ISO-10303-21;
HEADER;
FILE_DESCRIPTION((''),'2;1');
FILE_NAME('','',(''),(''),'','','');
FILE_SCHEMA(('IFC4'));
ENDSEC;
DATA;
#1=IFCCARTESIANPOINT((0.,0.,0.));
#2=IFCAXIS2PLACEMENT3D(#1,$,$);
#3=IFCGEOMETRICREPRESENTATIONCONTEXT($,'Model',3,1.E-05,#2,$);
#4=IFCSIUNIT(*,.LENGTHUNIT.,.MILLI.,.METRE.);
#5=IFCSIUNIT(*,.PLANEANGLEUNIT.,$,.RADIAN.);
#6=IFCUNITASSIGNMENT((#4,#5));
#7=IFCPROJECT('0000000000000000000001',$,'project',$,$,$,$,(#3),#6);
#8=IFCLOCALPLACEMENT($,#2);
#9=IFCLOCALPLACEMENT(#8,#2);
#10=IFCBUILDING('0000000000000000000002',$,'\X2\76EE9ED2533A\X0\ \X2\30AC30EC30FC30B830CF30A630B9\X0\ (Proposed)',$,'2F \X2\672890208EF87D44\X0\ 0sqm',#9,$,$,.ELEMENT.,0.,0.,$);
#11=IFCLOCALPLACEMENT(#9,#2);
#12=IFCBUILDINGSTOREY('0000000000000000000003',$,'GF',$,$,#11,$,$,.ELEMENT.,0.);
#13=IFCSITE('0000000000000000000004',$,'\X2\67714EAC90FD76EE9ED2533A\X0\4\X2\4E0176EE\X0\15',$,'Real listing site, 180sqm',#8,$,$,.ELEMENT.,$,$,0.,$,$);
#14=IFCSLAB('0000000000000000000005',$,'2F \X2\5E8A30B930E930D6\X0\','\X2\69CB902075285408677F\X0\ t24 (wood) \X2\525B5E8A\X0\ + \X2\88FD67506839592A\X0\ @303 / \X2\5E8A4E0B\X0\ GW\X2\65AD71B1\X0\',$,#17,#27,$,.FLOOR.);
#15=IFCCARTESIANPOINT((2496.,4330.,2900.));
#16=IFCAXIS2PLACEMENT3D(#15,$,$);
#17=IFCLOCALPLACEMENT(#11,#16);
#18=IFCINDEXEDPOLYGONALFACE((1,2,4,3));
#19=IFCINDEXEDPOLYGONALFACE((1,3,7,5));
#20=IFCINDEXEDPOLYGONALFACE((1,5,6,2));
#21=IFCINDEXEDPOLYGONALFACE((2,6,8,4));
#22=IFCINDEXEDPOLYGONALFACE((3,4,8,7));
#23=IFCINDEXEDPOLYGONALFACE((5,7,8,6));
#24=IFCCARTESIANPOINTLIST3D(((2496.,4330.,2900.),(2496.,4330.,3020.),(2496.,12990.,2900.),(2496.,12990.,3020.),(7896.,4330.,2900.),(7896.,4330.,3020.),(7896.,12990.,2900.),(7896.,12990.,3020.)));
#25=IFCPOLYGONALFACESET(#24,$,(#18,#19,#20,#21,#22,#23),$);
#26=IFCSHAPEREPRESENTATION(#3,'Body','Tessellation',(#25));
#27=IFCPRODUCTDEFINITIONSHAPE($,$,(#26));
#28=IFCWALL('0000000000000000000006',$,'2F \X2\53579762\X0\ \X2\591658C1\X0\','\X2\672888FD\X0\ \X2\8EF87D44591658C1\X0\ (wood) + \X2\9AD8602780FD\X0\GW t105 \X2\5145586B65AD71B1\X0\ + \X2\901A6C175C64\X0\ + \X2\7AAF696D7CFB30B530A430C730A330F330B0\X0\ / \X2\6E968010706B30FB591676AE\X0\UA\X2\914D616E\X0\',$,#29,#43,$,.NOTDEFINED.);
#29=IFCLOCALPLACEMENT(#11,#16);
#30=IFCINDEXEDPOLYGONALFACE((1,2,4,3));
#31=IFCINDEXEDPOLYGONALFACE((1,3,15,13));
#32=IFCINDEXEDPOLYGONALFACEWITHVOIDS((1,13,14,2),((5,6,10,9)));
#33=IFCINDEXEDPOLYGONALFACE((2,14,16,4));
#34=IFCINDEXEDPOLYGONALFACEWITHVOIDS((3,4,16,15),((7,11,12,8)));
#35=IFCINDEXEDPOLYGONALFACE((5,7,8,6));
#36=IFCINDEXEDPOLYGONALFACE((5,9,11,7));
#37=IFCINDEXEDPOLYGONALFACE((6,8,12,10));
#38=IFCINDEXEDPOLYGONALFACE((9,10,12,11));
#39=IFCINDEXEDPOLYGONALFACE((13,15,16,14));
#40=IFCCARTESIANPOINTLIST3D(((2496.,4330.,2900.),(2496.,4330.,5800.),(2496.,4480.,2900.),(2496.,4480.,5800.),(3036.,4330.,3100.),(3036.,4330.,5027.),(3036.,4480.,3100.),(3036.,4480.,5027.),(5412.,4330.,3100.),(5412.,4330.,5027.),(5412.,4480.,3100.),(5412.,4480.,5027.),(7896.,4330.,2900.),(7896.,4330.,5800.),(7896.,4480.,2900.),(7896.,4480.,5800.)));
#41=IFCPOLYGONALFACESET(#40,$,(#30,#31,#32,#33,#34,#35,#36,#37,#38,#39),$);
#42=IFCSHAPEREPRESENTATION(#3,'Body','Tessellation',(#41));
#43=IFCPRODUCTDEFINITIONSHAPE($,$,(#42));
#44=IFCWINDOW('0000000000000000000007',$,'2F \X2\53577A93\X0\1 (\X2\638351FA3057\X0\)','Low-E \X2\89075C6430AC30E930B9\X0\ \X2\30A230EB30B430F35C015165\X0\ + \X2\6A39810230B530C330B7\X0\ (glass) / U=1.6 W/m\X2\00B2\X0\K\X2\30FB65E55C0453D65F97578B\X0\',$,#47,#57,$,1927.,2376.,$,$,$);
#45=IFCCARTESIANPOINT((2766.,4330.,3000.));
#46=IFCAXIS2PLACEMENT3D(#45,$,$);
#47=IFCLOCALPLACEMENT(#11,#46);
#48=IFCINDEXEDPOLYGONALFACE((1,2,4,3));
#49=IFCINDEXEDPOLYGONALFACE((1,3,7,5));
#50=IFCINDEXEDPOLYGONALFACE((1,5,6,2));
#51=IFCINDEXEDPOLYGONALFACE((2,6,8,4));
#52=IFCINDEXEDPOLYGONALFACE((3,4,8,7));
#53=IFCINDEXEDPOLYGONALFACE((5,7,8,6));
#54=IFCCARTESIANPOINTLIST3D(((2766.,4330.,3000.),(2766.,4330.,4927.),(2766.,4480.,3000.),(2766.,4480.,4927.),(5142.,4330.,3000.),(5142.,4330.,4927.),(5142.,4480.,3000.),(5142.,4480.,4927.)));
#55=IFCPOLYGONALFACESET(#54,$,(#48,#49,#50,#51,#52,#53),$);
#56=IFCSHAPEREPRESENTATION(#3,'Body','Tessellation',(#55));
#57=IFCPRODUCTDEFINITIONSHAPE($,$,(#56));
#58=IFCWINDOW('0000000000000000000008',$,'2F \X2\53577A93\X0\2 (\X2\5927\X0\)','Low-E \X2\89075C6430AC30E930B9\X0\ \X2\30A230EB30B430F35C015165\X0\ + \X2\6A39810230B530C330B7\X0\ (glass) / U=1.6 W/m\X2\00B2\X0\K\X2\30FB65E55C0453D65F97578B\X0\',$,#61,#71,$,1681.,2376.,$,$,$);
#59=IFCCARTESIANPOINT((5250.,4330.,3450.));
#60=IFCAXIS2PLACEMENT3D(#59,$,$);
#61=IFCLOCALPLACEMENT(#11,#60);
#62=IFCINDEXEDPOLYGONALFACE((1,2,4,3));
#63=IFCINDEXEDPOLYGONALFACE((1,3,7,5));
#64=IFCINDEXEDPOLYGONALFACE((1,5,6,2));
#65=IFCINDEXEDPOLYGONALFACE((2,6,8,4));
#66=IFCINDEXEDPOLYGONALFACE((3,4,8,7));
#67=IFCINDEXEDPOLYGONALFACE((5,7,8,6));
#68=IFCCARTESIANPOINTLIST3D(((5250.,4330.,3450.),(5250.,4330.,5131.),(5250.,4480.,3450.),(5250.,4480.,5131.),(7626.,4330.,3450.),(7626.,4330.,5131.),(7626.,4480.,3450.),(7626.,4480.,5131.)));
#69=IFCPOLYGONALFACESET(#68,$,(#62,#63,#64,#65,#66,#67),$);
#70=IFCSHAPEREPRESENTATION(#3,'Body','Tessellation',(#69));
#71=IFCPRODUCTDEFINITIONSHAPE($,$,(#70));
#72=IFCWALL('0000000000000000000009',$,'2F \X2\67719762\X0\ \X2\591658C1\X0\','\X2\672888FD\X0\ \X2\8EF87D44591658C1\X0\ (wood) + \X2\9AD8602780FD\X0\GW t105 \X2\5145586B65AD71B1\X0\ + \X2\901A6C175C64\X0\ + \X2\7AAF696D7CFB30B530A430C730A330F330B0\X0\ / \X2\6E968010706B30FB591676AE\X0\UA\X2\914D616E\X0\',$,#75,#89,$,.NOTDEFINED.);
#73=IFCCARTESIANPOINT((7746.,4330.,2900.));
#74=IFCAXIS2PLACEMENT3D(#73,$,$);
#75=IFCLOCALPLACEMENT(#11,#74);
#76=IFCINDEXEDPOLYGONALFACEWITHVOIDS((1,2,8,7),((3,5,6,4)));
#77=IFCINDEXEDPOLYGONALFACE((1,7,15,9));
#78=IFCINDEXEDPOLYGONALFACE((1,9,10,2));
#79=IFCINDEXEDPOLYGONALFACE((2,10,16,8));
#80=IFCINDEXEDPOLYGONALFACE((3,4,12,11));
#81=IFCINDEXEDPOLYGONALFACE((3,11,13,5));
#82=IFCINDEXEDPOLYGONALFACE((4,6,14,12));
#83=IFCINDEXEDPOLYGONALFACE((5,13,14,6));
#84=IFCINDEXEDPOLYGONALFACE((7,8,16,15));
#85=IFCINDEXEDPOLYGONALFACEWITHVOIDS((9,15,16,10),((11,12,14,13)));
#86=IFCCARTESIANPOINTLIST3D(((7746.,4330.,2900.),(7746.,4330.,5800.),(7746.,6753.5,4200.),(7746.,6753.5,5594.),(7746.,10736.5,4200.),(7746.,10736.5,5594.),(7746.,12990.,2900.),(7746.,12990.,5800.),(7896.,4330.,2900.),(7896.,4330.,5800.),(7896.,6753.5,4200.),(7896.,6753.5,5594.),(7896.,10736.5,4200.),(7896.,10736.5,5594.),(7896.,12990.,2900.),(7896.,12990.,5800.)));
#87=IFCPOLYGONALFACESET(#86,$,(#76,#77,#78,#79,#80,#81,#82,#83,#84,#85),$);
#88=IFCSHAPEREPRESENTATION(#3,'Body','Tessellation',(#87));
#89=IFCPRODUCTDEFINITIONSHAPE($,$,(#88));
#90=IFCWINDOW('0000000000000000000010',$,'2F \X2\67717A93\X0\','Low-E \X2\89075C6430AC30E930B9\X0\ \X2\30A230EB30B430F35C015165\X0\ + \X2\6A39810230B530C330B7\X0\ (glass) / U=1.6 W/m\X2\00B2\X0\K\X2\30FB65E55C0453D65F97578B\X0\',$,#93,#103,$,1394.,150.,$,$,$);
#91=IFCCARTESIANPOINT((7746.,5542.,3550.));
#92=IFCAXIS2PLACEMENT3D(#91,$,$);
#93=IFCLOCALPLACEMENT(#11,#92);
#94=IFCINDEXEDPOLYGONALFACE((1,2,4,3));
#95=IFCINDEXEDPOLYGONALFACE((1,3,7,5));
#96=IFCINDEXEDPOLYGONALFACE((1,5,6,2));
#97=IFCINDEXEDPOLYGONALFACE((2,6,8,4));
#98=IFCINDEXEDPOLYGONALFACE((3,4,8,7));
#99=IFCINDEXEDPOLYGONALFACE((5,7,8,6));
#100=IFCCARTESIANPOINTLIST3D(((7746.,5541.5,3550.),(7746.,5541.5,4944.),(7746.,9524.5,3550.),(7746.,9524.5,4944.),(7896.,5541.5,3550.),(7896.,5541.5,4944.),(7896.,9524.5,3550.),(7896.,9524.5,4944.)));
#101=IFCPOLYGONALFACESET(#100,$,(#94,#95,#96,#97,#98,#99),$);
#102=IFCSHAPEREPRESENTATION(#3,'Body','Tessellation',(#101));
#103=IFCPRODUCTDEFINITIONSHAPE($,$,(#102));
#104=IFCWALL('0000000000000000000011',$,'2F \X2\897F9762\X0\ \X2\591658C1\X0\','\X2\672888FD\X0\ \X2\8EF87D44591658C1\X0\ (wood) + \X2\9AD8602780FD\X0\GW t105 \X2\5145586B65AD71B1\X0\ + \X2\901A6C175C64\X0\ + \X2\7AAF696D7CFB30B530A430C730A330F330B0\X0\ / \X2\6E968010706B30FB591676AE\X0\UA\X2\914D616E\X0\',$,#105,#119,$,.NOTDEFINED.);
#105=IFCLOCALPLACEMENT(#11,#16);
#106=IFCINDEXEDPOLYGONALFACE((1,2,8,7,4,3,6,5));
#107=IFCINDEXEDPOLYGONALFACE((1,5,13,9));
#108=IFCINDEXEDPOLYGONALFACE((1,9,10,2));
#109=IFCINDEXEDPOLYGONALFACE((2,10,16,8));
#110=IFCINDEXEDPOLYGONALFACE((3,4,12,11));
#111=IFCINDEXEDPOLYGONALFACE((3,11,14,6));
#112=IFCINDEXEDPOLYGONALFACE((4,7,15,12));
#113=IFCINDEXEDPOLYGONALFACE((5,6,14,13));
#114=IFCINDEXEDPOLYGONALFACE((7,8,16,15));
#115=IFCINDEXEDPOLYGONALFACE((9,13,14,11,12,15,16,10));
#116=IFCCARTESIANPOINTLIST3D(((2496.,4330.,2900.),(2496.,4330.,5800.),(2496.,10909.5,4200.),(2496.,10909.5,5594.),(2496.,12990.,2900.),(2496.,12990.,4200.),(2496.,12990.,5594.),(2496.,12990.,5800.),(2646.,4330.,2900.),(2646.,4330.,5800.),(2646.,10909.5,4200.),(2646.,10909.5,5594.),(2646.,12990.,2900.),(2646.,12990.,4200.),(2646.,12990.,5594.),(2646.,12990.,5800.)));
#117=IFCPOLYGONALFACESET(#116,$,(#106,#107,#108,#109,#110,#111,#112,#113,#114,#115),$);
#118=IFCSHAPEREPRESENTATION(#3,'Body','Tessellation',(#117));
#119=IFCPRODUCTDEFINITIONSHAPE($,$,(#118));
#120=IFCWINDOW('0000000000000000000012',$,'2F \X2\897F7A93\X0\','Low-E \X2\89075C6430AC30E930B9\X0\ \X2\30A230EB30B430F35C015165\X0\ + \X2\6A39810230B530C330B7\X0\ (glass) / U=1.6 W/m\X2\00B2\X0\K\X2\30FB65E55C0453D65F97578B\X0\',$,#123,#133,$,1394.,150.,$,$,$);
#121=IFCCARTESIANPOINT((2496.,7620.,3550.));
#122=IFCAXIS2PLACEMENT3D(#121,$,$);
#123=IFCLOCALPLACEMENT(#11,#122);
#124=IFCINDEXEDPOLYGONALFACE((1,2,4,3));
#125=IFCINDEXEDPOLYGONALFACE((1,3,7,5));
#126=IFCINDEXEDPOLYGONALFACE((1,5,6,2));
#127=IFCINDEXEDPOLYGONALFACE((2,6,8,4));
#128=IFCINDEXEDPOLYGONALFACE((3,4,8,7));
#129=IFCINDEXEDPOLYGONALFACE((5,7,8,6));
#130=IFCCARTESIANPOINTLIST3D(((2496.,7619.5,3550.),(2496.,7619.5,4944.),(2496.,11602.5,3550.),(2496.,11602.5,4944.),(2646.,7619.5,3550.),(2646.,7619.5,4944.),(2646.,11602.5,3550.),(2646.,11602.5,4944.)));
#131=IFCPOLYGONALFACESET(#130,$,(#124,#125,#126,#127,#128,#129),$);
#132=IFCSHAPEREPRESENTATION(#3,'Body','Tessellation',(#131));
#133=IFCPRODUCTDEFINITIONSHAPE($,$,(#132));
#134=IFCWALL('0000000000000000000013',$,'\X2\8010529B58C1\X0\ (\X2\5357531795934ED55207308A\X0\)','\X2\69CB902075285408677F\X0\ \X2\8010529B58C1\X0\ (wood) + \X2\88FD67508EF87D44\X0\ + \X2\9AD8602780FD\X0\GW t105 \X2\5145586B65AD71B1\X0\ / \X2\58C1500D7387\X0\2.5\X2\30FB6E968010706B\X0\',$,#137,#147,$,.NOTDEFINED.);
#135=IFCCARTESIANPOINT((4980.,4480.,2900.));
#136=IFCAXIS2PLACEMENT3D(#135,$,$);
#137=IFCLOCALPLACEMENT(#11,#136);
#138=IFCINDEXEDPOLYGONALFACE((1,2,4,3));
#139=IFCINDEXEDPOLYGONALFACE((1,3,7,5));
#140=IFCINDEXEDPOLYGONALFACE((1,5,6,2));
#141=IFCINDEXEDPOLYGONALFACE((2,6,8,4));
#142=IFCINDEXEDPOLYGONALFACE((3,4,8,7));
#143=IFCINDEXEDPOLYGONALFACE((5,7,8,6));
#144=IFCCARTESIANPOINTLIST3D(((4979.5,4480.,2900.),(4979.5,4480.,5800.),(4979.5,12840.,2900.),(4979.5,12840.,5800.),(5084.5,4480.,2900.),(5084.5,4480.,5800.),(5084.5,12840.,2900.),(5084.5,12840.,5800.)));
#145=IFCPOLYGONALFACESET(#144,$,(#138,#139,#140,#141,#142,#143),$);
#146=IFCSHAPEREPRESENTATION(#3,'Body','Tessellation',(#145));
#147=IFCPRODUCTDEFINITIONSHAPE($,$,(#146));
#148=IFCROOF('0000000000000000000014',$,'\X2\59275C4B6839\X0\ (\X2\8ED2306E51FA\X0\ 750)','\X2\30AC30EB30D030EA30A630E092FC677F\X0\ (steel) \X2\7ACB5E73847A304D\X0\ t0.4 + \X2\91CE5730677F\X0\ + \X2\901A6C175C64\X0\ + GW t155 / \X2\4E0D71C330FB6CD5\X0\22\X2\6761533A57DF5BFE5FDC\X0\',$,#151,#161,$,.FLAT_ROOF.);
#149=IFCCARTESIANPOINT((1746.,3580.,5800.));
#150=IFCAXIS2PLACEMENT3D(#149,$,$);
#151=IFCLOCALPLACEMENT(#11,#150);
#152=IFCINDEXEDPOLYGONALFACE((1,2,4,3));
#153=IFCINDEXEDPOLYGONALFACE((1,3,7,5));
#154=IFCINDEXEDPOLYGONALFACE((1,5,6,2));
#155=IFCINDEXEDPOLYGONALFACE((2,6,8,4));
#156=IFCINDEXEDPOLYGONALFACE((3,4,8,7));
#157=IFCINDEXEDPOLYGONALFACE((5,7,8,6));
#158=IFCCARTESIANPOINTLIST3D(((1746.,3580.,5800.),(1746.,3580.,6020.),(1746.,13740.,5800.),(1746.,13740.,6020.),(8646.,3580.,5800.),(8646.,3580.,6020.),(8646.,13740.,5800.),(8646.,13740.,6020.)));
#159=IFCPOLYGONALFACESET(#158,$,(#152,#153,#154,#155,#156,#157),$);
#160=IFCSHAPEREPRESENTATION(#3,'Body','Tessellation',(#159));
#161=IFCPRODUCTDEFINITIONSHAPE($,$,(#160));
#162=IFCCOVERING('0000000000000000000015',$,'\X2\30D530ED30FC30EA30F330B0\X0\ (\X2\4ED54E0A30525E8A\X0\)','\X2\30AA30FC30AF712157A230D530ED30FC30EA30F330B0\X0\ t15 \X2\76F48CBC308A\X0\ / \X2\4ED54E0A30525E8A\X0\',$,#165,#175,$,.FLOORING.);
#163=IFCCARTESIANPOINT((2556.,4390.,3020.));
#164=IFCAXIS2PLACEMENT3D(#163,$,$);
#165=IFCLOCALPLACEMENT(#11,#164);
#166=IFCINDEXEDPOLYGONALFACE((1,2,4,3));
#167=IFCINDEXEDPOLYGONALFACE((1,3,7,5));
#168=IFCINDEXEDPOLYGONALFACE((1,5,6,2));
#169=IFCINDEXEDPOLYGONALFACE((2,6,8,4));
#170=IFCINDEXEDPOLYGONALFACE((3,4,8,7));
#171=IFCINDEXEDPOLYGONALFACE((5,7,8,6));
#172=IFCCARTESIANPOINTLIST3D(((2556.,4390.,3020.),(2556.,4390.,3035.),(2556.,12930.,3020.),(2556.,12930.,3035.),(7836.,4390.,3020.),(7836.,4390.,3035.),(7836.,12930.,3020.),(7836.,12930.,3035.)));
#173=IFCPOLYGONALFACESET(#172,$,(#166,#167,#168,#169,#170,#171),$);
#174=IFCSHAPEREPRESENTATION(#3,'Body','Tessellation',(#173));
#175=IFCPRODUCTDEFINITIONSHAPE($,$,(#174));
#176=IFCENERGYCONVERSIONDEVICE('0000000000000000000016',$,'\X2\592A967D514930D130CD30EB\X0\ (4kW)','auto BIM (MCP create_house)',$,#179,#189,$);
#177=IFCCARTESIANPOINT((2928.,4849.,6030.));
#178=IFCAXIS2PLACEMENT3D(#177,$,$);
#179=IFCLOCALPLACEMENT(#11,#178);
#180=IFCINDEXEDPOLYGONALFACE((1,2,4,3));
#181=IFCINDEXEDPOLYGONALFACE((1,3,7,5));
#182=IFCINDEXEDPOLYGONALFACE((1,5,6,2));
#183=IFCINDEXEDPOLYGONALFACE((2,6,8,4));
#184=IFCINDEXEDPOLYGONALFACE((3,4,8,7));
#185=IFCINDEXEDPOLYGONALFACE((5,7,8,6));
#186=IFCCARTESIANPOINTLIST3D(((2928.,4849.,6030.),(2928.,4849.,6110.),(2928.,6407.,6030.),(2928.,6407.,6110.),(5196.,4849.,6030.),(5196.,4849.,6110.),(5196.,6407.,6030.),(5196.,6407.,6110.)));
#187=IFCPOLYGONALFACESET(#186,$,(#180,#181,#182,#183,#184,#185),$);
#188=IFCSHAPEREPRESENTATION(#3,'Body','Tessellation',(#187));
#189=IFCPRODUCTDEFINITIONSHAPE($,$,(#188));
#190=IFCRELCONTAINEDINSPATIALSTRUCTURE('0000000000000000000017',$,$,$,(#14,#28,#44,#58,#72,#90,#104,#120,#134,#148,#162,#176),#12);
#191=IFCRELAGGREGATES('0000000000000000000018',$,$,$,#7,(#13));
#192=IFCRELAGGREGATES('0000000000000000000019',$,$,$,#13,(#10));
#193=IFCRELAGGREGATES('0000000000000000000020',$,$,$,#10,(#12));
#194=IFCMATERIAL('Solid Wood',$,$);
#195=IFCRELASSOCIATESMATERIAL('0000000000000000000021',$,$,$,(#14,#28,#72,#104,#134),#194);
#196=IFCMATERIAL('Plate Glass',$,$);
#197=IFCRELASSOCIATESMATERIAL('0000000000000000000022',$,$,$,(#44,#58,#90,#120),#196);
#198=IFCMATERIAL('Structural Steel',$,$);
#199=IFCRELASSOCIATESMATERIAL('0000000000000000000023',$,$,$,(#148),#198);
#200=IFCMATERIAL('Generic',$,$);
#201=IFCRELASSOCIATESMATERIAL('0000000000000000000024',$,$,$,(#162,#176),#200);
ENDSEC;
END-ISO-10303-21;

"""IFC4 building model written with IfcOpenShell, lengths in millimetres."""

from ifc_helpers import new_model, si_unit, frame, frame_2d, origin, place, context, project, spatial, rectangle, extrude, material, element, fill, save


model = new_model("IFC4")

# Units and contexts
model_context = context("Model", 3, precision=1e-05, world=origin())
ifc_project = project(units=[si_unit("LENGTHUNIT", "METRE", prefix="MILLI"), si_unit("PLANEANGLEUNIT", "RADIAN")], contexts=[model_context])

# Site, building, storey
site_placement = place(None, origin())
site = spatial("IfcSite", under=ifc_project, at=site_placement, Name="東京都目黒区4丁目15", ObjectType="Real listing site, 180sqm", CompositionType="ELEMENT", RefElevation=0.0)
building_placement = place(site_placement, origin())
building = spatial("IfcBuilding", under=site, at=building_placement, Name="目黒区 ガレージハウス (Proposed)", ObjectType="2F 木造軸組 0sqm", CompositionType="ELEMENT", ElevationOfRefHeight=0.0, ElevationOfTerrain=0.0)
storey_placement = place(building_placement, origin())
storey = spatial("IfcBuildingStorey", under=building, at=storey_placement, Name="GF", CompositionType="ELEMENT", Elevation=0.0)

# Slab
ifc_material_1 = material(Name="Solid Wood")
slab_placement = place(storey_placement, frame((2496.0, 4330.0, 2900.0)))
element("IfcSlab", 1, at=slab_placement, inside=storey, material=ifc_material_1, Name="2F 床スラブ", Description="構造用合板 t24 (wood) 剛床 + 製材根太 @303 / 床下 GW断熱", PredefinedType="FLOOR", context=model_context, shape_type="SweptSolid", body=[
    extrude(rectangle(XDim=5400.0, YDim=8660.0, at=frame_2d((2700.0, 4330.0))), frame((2496.0, 4330.0, 2900.0)), (0.0, 0.0, 1.0), 120.0),
])

# Wall, openings, windows
wall_1_placement = place(storey_placement, frame((2496.0, 4330.0, 2900.0)))
wall_1 = element("IfcWall", 2, at=wall_1_placement, inside=storey, material=ifc_material_1, Name="2F 南面 外壁", Description="木製 軸組外壁 (wood) + 高性能GW t105 充填断熱 + 通気層 + 窯業系サイディング / 準耐火・外皮UA配慮", PredefinedType="NOTDEFINED", context=model_context, shape_type="SweptSolid", body=[
    extrude(rectangle(XDim=5400.0, YDim=150.0, at=frame_2d((2700.0, 75.0))), frame((2496.0, 4330.0, 2900.0)), (0.0, 0.0, 1.0), 2900.0),
])
opening_1_placement = place(storey_placement, frame((2766.0, 4330.0, 3000.0)))
opening_1 = element("IfcOpeningElement", 3, at=opening_1_placement, cuts=wall_1, PredefinedType="NOTDEFINED", context=model_context, shape_type="SweptSolid", body=[
    extrude(rectangle(XDim=2376.0, YDim=150.0, at=frame_2d((1188.0, 75.0))), frame((2766.0, 4330.0, 3000.0)), (0.0, 0.0, 1.0), 1927.0),
])
opening_2_placement = place(storey_placement, frame((5250.0, 4330.0, 3450.0)))
opening_2 = element("IfcOpeningElement", 4, at=opening_2_placement, cuts=wall_1, PredefinedType="NOTDEFINED", context=model_context, shape_type="SweptSolid", body=[
    extrude(rectangle(XDim=2376.0, YDim=150.0, at=frame_2d((1188.0, 75.0))), frame((5250.0, 4330.0, 3450.0)), (0.0, 0.0, 1.0), 1681.0),
])
ifc_material_2 = material(Name="Plate Glass")
window_1_placement = place(storey_placement, frame((2766.0, 4330.0, 3000.0)))
window_1 = element("IfcWindow", 5, at=window_1_placement, inside=storey, material=ifc_material_2, Name="2F 南窓1 (掃出し)", Description="Low-E 複層ガラス アルゴン封入 + 樹脂サッシ (glass) / U=1.6 W/m²K・日射取得型", OverallHeight=1927.0, OverallWidth=2376.0, context=model_context, shape_type="SweptSolid", body=[
    extrude(rectangle(XDim=2376.0, YDim=150.0, at=frame_2d((1188.0, 75.0))), frame((2766.0, 4330.0, 3000.0)), (0.0, 0.0, 1.0), 1927.0),
])
fill(opening_1, window_1)
window_2_placement = place(storey_placement, frame((5250.0, 4330.0, 3450.0)))
window_2 = element("IfcWindow", 6, at=window_2_placement, inside=storey, material=ifc_material_2, Name="2F 南窓2 (大)", Description="Low-E 複層ガラス アルゴン封入 + 樹脂サッシ (glass) / U=1.6 W/m²K・日射取得型", OverallHeight=1681.0, OverallWidth=2376.0, context=model_context, shape_type="SweptSolid", body=[
    extrude(rectangle(XDim=2376.0, YDim=150.0, at=frame_2d((1188.0, 75.0))), frame((5250.0, 4330.0, 3450.0)), (0.0, 0.0, 1.0), 1681.0),
])
fill(opening_2, window_2)

# Walls, openings, windows
wall_2_placement = place(storey_placement, frame((7746.0, 4330.0, 2900.0)))
wall_2 = element("IfcWall", 7, at=wall_2_placement, inside=storey, material=ifc_material_1, Name="2F 東面 外壁", Description="木製 軸組外壁 (wood) + 高性能GW t105 充填断熱 + 通気層 + 窯業系サイディング / 準耐火・外皮UA配慮", PredefinedType="NOTDEFINED", context=model_context, shape_type="SweptSolid", body=[
    extrude(rectangle(XDim=150.0, YDim=8660.0, at=frame_2d((75.0, 4330.0))), frame((7746.0, 4330.0, 2900.0)), (0.0, 0.0, 1.0), 2900.0),
])
opening_3_placement = place(storey_placement, frame((7746.0, 5542.0, 3550.0)))
opening_3 = element("IfcOpeningElement", 8, at=opening_3_placement, cuts=wall_2, PredefinedType="NOTDEFINED", context=model_context, shape_type="SweptSolid", body=[
    extrude(rectangle(XDim=150.0, YDim=3983.0, at=frame_2d((75.0, 1991.0))), frame((7746.0, 5542.0, 3550.0)), (0.0, 0.0, 1.0), 1394.0),
])
window_3_placement = place(storey_placement, frame((7746.0, 5542.0, 3550.0)))
window_3 = element("IfcWindow", 9, at=window_3_placement, inside=storey, material=ifc_material_2, Name="2F 東窓", Description="Low-E 複層ガラス アルゴン封入 + 樹脂サッシ (glass) / U=1.6 W/m²K・日射取得型", OverallHeight=1394.0, OverallWidth=150.0, context=model_context, shape_type="SweptSolid", body=[
    extrude(rectangle(XDim=150.0, YDim=3983.0, at=frame_2d((75.0, 1991.0))), frame((7746.0, 5542.0, 3550.0)), (0.0, 0.0, 1.0), 1394.0),
])
fill(opening_3, window_3)
wall_3_placement = place(storey_placement, frame((2496.0, 4330.0, 2900.0)))
wall_3 = element("IfcWall", 10, at=wall_3_placement, inside=storey, material=ifc_material_1, Name="2F 西面 外壁", Description="木製 軸組外壁 (wood) + 高性能GW t105 充填断熱 + 通気層 + 窯業系サイディング / 準耐火・外皮UA配慮", PredefinedType="NOTDEFINED", context=model_context, shape_type="SweptSolid", body=[
    extrude(rectangle(XDim=150.0, YDim=8660.0, at=frame_2d((75.0, 4330.0))), frame((2496.0, 4330.0, 2900.0)), (0.0, 0.0, 1.0), 2900.0),
])
opening_4_placement = place(storey_placement, frame((2496.0, 7620.0, 3550.0)))
opening_4 = element("IfcOpeningElement", 11, at=opening_4_placement, cuts=wall_3, PredefinedType="NOTDEFINED", context=model_context, shape_type="SweptSolid", body=[
    extrude(rectangle(XDim=150.0, YDim=3983.0, at=frame_2d((75.0, 1991.0))), frame((2496.0, 7620.0, 3550.0)), (0.0, 0.0, 1.0), 1394.0),
])
window_4_placement = place(storey_placement, frame((2496.0, 7620.0, 3550.0)))
window_4 = element("IfcWindow", 12, at=window_4_placement, inside=storey, material=ifc_material_2, Name="2F 西窓", Description="Low-E 複層ガラス アルゴン封入 + 樹脂サッシ (glass) / U=1.6 W/m²K・日射取得型", OverallHeight=1394.0, OverallWidth=150.0, context=model_context, shape_type="SweptSolid", body=[
    extrude(rectangle(XDim=150.0, YDim=3983.0, at=frame_2d((75.0, 1991.0))), frame((2496.0, 7620.0, 3550.0)), (0.0, 0.0, 1.0), 1394.0),
])
fill(opening_4, window_4)

# Wall
wall_4_placement = place(storey_placement, frame((4980.0, 4480.0, 2900.0)))
element("IfcWall", 13, at=wall_4_placement, inside=storey, material=ifc_material_1, Name="耐力壁 (南北間仕切り)", Description="構造用合板 耐力壁 (wood) + 製材軸組 + 高性能GW t105 充填断熱 / 壁倍率2.5・準耐火", PredefinedType="NOTDEFINED", context=model_context, shape_type="SweptSolid", body=[
    extrude(rectangle(XDim=105.0, YDim=8360.0, at=frame_2d((52.0, 4180.0))), frame((4980.0, 4480.0, 2900.0)), (0.0, 0.0, 1.0), 2900.0),
])

# Roof
ifc_material_3 = material(Name="Structural Steel")
roof_placement = place(storey_placement, frame((1746.0, 3580.0, 5800.0)))
element("IfcRoof", 14, at=roof_placement, inside=storey, material=ifc_material_3, Name="大屋根 (軒の出 750)", Description="ガルバリウム鋼板 (steel) 立平葺き t0.4 + 野地板 + 通気層 + GW t155 / 不燃・法22条区域対応", PredefinedType="FLAT_ROOF", context=model_context, shape_type="SweptSolid", body=[
    extrude(rectangle(XDim=6900.0, YDim=10160.0, at=frame_2d((3450.0, 5080.0))), frame((1746.0, 3580.0, 5800.0)), (0.0, 0.0, 1.0), 220.0),
])

# Covering
ifc_material_4 = material(Name="Generic")
covering_placement = place(storey_placement, frame((2556.0, 4390.0, 3020.0)))
element("IfcCovering", 15, at=covering_placement, inside=storey, material=ifc_material_4, Name="フローリング (仕上げ床)", Description="オーク無垢フローリング t15 直貼り / 仕上げ床", PredefinedType="FLOORING", context=model_context, shape_type="SweptSolid", body=[
    extrude(rectangle(XDim=5280.0, YDim=8540.0, at=frame_2d((2640.0, 4270.0))), frame((2556.0, 4390.0, 3020.0)), (0.0, 0.0, 1.0), 15.0),
])

# Energy conversion device
energy_conversion_device_placement = place(storey_placement, frame((2928.0, 4849.0, 6030.0)))
element("IfcEnergyConversionDevice", 16, at=energy_conversion_device_placement, inside=storey, material=ifc_material_4, Name="太陽光パネル (4kW)", Description="auto BIM (MCP create_house)", context=model_context, shape_type="SweptSolid", body=[
    extrude(rectangle(XDim=2268.0, YDim=1558.0, at=frame_2d((1134.0, 779.0))), frame((2928.0, 4849.0, 6030.0)), (0.0, 0.0, 1.0), 80.0),
])

save(model, "model.ifc")
